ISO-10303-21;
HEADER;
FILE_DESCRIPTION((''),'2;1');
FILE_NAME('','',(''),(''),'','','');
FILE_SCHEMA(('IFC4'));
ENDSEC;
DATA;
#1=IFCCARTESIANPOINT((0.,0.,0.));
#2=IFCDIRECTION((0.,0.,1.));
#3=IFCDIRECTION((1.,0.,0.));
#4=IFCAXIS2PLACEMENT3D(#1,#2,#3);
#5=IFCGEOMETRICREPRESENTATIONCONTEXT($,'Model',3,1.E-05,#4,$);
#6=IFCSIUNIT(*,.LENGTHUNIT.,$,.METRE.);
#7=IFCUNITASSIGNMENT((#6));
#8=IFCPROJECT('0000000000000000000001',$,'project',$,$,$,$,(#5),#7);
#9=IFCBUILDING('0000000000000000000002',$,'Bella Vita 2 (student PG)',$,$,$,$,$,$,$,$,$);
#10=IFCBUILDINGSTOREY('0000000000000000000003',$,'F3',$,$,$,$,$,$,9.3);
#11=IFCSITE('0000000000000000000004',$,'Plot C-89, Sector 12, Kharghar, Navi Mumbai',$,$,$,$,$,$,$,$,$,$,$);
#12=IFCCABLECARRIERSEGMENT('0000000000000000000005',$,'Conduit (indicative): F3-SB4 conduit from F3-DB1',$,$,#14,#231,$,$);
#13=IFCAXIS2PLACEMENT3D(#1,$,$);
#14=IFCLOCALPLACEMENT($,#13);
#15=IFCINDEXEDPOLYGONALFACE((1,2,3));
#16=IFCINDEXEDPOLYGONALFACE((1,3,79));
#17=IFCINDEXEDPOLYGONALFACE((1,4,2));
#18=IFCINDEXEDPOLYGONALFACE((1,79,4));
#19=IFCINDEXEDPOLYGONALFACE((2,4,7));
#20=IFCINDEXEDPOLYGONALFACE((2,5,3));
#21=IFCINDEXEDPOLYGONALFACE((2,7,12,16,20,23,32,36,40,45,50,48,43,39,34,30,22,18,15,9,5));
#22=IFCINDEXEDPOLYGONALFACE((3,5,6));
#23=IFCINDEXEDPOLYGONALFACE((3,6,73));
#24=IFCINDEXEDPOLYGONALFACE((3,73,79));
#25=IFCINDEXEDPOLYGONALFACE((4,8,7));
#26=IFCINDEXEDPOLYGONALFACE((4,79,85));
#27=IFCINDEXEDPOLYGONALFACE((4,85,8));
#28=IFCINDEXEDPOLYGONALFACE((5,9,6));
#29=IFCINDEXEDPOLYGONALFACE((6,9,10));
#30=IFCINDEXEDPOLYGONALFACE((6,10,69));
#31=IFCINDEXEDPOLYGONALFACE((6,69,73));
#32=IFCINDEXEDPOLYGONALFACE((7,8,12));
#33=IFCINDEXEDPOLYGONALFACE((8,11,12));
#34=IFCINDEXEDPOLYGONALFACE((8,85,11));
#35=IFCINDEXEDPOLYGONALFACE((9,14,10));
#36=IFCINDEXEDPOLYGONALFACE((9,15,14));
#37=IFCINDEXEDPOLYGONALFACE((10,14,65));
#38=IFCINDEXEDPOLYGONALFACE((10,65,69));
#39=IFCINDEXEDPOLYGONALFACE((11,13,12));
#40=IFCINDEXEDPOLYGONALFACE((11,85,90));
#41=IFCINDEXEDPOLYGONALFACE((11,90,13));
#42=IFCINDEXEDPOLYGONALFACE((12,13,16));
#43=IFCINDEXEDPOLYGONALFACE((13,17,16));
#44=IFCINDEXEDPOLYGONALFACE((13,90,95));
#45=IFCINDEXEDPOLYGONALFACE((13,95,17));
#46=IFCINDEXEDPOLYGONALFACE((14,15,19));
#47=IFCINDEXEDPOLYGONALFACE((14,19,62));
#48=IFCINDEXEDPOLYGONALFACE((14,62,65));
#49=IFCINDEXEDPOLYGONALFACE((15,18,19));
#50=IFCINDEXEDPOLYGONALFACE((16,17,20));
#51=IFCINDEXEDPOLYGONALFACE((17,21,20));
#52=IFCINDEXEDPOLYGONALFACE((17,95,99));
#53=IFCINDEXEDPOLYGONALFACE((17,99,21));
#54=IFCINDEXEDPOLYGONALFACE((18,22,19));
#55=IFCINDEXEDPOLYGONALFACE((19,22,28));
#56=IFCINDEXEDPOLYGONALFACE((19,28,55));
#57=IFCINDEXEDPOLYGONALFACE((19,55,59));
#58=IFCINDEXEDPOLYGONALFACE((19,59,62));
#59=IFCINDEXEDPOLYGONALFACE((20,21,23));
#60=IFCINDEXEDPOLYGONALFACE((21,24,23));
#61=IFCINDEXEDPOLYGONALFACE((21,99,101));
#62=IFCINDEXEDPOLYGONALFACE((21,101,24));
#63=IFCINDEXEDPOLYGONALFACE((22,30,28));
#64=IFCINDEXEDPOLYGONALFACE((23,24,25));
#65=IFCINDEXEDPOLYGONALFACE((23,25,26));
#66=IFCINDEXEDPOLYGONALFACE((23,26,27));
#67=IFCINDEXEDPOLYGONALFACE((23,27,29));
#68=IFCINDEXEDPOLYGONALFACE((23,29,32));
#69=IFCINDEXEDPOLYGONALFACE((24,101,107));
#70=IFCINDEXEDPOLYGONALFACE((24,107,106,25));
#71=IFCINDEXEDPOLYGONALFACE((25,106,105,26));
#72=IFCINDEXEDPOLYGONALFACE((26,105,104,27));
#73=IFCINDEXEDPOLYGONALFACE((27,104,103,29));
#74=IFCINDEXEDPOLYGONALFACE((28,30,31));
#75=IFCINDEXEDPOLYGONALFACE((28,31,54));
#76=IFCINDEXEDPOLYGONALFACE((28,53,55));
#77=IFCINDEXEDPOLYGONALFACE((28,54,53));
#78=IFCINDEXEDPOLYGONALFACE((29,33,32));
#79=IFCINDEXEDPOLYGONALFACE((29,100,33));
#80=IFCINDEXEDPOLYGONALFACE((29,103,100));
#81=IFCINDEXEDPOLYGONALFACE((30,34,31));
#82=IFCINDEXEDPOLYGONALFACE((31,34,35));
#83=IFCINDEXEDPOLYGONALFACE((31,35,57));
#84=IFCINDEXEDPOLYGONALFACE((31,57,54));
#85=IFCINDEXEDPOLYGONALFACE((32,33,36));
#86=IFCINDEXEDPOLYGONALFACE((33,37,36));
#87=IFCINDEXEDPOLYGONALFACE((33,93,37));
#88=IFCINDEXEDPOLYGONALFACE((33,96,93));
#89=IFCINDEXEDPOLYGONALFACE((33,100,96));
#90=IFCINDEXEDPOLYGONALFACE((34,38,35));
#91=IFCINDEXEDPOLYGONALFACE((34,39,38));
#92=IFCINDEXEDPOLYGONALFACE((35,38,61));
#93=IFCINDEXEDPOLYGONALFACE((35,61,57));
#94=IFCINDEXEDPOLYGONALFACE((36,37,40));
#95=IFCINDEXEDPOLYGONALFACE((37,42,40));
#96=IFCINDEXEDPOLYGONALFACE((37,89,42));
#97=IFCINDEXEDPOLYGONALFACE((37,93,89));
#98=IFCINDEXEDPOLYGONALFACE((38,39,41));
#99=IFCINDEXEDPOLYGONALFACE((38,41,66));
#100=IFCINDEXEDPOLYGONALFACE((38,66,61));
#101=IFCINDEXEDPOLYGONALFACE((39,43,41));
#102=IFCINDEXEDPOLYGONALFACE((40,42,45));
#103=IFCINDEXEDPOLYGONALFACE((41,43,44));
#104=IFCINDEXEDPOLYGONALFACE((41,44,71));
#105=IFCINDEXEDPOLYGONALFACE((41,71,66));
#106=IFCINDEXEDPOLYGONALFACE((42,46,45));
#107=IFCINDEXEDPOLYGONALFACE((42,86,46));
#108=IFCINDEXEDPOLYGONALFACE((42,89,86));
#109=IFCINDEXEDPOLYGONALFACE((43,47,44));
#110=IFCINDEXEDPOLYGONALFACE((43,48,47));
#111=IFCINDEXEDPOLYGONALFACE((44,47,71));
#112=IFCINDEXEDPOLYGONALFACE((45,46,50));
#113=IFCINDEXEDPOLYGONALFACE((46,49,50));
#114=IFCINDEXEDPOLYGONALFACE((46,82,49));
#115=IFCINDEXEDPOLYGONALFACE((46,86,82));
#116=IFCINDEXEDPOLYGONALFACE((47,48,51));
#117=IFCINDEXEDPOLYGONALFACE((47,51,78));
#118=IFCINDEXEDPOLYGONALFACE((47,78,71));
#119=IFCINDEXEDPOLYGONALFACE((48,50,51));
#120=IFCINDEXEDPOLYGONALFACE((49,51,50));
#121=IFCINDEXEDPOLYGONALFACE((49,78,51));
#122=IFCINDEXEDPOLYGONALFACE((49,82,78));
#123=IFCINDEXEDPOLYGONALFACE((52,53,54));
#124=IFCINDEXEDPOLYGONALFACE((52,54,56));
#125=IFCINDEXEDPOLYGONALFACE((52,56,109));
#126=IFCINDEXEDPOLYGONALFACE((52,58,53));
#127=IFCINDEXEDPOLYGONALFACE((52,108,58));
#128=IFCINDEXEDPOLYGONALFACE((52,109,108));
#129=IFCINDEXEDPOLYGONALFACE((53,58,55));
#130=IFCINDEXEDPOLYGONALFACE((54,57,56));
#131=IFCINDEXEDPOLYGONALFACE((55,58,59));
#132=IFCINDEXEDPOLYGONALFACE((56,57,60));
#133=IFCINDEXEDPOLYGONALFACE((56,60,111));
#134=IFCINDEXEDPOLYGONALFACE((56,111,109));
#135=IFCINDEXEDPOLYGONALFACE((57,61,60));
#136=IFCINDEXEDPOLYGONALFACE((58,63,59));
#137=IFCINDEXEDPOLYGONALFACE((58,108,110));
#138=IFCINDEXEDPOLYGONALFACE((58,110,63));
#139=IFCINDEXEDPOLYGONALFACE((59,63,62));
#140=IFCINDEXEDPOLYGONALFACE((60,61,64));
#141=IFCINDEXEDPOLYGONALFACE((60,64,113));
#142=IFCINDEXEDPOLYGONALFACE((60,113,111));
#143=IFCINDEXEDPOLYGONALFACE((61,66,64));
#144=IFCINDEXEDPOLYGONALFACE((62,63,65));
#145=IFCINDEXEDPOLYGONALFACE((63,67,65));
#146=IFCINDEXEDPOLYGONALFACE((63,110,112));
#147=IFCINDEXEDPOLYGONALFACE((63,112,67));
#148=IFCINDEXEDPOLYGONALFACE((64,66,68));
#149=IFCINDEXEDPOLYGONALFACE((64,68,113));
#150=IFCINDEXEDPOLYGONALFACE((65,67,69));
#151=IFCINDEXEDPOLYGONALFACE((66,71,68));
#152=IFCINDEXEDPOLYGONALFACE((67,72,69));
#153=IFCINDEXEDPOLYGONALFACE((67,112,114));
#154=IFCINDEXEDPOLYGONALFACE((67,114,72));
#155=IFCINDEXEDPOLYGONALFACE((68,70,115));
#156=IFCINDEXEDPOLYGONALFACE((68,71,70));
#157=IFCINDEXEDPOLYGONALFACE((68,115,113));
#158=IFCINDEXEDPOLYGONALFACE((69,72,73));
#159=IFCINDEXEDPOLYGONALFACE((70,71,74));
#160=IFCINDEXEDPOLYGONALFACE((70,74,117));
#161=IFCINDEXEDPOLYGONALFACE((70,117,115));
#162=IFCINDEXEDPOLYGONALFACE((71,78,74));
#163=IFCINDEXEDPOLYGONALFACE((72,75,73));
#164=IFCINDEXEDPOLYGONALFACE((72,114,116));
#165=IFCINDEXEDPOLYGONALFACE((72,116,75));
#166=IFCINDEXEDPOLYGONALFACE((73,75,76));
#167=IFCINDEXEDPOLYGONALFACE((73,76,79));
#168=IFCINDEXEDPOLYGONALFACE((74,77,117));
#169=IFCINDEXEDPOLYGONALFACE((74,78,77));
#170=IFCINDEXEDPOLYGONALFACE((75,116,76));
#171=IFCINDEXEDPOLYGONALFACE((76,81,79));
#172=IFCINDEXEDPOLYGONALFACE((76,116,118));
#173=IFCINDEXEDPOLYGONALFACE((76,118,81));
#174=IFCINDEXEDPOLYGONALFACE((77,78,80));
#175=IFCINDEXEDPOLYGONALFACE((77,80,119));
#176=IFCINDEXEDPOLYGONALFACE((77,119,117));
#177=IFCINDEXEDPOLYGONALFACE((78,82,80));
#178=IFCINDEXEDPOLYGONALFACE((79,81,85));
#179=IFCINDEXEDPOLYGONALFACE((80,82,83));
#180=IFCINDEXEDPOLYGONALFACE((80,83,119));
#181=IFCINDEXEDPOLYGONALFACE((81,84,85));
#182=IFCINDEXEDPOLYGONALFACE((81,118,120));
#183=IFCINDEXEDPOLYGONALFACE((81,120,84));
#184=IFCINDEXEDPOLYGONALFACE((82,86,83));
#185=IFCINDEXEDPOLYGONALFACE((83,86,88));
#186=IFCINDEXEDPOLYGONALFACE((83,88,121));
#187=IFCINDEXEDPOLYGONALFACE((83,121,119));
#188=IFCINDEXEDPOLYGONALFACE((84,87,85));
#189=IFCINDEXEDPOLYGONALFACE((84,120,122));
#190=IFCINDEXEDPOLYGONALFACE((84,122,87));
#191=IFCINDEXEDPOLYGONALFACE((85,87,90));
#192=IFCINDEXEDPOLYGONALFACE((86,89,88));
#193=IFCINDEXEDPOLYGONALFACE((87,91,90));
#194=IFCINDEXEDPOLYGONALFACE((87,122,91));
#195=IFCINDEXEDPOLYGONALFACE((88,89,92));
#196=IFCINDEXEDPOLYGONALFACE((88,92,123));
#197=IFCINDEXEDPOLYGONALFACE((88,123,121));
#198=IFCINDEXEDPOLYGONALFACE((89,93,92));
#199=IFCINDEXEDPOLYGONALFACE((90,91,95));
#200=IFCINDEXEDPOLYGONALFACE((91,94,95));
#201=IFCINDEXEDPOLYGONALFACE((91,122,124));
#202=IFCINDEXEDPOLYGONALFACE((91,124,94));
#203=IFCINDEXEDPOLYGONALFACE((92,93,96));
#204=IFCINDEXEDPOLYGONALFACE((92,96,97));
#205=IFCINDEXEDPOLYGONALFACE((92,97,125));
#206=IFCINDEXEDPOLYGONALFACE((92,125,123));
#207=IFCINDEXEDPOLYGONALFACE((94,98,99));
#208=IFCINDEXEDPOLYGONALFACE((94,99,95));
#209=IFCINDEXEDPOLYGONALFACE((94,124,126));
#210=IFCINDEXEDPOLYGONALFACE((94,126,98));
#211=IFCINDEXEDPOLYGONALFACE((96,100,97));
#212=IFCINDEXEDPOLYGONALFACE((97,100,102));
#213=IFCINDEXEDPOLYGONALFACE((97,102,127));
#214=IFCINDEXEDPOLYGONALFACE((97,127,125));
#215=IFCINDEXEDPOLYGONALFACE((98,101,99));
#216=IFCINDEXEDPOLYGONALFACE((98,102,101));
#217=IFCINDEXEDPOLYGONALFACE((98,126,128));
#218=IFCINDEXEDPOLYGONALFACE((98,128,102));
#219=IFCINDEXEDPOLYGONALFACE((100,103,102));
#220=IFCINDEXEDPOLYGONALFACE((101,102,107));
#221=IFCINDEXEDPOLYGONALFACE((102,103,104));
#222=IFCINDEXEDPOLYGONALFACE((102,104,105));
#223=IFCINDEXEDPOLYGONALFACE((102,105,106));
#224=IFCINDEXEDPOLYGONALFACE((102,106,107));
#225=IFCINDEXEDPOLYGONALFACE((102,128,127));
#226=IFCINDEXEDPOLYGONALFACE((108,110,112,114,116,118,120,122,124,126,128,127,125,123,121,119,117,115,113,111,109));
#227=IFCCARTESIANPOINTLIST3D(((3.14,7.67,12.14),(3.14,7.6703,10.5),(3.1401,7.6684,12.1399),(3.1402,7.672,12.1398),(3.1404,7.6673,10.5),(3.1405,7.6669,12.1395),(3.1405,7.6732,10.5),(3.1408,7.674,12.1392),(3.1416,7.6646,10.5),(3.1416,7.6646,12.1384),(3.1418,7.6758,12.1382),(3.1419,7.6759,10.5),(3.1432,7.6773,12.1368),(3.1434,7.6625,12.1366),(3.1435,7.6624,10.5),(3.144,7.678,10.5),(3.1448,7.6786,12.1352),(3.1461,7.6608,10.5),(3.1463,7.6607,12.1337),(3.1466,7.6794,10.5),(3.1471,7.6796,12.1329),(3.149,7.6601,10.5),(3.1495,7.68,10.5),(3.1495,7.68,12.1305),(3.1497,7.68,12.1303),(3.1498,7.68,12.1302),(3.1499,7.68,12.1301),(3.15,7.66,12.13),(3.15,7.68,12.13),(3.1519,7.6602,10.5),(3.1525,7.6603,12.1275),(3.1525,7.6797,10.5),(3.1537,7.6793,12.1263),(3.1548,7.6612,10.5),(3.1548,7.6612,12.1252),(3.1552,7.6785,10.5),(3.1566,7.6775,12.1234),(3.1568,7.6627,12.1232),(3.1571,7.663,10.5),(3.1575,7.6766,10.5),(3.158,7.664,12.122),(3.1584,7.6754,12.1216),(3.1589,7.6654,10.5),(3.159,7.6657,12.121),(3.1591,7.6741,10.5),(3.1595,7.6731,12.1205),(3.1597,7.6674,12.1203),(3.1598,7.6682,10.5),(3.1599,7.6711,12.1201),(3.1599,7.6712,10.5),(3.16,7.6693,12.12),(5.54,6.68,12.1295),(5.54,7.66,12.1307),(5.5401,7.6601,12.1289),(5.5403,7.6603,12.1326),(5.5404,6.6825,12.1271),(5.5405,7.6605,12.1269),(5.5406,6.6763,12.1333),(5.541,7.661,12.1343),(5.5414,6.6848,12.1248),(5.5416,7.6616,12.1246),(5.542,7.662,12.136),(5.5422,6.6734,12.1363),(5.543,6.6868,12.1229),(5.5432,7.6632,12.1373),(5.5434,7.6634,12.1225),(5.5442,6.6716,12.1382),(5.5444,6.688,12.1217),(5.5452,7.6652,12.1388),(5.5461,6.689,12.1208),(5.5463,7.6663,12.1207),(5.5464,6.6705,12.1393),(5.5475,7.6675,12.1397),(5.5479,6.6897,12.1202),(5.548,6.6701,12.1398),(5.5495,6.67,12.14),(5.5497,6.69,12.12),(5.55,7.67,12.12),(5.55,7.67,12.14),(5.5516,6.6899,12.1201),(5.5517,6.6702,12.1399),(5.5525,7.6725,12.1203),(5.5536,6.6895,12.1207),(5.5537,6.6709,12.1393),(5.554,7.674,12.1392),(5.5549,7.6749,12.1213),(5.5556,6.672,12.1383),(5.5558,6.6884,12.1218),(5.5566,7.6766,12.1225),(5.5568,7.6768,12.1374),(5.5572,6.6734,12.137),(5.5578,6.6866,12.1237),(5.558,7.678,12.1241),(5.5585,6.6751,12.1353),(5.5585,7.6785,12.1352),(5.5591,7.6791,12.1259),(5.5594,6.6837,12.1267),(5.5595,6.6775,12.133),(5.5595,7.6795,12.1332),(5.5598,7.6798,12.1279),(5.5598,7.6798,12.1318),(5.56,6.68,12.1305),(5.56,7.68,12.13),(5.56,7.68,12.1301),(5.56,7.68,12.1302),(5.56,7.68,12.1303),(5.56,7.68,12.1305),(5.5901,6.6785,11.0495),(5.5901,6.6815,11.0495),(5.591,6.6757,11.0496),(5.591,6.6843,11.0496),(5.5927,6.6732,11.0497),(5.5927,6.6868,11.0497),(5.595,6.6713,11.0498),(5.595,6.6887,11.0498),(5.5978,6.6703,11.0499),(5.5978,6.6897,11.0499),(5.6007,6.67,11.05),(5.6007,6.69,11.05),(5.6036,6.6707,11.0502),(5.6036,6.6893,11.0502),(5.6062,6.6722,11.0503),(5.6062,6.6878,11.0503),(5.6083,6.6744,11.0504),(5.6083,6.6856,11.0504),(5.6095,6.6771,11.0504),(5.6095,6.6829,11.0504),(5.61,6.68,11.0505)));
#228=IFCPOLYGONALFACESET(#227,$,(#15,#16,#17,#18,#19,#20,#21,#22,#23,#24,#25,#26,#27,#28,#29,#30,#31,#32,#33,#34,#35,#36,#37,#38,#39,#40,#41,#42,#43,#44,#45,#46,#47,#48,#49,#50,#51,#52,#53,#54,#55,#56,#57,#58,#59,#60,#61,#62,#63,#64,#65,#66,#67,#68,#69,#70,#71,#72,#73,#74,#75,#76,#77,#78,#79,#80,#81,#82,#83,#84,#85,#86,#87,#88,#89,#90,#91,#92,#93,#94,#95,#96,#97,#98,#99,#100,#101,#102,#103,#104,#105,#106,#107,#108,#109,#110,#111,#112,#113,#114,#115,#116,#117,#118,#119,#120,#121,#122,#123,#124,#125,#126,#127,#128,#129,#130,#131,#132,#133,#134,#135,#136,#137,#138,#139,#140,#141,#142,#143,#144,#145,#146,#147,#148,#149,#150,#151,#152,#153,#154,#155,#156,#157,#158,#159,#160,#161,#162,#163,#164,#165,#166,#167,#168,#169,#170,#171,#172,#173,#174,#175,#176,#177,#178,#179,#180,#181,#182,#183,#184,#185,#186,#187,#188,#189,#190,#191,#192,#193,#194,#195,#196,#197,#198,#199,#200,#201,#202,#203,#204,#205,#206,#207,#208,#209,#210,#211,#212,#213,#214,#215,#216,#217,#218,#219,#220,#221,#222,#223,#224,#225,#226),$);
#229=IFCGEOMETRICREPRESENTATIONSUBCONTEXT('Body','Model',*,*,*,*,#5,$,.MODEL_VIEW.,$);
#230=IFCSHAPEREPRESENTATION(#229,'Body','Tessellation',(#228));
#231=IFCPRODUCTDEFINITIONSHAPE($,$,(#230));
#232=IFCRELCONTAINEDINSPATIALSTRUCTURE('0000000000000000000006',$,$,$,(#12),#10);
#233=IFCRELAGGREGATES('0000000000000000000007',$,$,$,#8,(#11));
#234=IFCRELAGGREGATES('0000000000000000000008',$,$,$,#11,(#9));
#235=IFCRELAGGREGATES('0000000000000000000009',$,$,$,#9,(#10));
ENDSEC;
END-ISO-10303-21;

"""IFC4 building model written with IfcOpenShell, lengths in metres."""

from ifc_helpers import new_model, entity, si_unit, origin, origin_with_axes, place, context, subcontext, project, spatial, element, save


model = new_model("IFC4")

# Units and contexts
model_context = context("Model", 3, precision=1e-05, world=origin_with_axes())
body_context = subcontext(model_context, "Body", "Model", "MODEL_VIEW")
ifc_project = project(units=[si_unit("LENGTHUNIT", "METRE")], contexts=[model_context])

# Site, building, storey
site = spatial("IfcSite", under=ifc_project, Name="Plot C-89, Sector 12, Kharghar, Navi Mumbai")
building = spatial("IfcBuilding", under=site, Name="Bella Vita 2 (student PG)")
storey = spatial("IfcBuildingStorey", under=building, Name="F3", Elevation=9.3)

# Cable carrier segment
cable_carrier_segment_1_placement = place(None, origin())
element("IfcCableCarrierSegment", 1, at=cable_carrier_segment_1_placement, inside=storey, Name="Conduit (indicative): F3-SB4 conduit from F3-DB1", context=body_context, shape_type="AdvancedSweptSolid", body=[
    entity("IfcSweptDiskSolid", entity("IfcPolyline", [entity("IfcCartesianPoint", [5.6, 6.68, 11.05]), entity("IfcCartesianPoint", [5.55, 6.68, 12.13]), entity("IfcCartesianPoint", [5.55, 7.67, 12.13]), entity("IfcCartesianPoint", [3.15, 7.67, 12.13]), entity("IfcCartesianPoint", [3.15, 7.67, 10.5])]), 0.01),
])

save(model, "model.ifc")
